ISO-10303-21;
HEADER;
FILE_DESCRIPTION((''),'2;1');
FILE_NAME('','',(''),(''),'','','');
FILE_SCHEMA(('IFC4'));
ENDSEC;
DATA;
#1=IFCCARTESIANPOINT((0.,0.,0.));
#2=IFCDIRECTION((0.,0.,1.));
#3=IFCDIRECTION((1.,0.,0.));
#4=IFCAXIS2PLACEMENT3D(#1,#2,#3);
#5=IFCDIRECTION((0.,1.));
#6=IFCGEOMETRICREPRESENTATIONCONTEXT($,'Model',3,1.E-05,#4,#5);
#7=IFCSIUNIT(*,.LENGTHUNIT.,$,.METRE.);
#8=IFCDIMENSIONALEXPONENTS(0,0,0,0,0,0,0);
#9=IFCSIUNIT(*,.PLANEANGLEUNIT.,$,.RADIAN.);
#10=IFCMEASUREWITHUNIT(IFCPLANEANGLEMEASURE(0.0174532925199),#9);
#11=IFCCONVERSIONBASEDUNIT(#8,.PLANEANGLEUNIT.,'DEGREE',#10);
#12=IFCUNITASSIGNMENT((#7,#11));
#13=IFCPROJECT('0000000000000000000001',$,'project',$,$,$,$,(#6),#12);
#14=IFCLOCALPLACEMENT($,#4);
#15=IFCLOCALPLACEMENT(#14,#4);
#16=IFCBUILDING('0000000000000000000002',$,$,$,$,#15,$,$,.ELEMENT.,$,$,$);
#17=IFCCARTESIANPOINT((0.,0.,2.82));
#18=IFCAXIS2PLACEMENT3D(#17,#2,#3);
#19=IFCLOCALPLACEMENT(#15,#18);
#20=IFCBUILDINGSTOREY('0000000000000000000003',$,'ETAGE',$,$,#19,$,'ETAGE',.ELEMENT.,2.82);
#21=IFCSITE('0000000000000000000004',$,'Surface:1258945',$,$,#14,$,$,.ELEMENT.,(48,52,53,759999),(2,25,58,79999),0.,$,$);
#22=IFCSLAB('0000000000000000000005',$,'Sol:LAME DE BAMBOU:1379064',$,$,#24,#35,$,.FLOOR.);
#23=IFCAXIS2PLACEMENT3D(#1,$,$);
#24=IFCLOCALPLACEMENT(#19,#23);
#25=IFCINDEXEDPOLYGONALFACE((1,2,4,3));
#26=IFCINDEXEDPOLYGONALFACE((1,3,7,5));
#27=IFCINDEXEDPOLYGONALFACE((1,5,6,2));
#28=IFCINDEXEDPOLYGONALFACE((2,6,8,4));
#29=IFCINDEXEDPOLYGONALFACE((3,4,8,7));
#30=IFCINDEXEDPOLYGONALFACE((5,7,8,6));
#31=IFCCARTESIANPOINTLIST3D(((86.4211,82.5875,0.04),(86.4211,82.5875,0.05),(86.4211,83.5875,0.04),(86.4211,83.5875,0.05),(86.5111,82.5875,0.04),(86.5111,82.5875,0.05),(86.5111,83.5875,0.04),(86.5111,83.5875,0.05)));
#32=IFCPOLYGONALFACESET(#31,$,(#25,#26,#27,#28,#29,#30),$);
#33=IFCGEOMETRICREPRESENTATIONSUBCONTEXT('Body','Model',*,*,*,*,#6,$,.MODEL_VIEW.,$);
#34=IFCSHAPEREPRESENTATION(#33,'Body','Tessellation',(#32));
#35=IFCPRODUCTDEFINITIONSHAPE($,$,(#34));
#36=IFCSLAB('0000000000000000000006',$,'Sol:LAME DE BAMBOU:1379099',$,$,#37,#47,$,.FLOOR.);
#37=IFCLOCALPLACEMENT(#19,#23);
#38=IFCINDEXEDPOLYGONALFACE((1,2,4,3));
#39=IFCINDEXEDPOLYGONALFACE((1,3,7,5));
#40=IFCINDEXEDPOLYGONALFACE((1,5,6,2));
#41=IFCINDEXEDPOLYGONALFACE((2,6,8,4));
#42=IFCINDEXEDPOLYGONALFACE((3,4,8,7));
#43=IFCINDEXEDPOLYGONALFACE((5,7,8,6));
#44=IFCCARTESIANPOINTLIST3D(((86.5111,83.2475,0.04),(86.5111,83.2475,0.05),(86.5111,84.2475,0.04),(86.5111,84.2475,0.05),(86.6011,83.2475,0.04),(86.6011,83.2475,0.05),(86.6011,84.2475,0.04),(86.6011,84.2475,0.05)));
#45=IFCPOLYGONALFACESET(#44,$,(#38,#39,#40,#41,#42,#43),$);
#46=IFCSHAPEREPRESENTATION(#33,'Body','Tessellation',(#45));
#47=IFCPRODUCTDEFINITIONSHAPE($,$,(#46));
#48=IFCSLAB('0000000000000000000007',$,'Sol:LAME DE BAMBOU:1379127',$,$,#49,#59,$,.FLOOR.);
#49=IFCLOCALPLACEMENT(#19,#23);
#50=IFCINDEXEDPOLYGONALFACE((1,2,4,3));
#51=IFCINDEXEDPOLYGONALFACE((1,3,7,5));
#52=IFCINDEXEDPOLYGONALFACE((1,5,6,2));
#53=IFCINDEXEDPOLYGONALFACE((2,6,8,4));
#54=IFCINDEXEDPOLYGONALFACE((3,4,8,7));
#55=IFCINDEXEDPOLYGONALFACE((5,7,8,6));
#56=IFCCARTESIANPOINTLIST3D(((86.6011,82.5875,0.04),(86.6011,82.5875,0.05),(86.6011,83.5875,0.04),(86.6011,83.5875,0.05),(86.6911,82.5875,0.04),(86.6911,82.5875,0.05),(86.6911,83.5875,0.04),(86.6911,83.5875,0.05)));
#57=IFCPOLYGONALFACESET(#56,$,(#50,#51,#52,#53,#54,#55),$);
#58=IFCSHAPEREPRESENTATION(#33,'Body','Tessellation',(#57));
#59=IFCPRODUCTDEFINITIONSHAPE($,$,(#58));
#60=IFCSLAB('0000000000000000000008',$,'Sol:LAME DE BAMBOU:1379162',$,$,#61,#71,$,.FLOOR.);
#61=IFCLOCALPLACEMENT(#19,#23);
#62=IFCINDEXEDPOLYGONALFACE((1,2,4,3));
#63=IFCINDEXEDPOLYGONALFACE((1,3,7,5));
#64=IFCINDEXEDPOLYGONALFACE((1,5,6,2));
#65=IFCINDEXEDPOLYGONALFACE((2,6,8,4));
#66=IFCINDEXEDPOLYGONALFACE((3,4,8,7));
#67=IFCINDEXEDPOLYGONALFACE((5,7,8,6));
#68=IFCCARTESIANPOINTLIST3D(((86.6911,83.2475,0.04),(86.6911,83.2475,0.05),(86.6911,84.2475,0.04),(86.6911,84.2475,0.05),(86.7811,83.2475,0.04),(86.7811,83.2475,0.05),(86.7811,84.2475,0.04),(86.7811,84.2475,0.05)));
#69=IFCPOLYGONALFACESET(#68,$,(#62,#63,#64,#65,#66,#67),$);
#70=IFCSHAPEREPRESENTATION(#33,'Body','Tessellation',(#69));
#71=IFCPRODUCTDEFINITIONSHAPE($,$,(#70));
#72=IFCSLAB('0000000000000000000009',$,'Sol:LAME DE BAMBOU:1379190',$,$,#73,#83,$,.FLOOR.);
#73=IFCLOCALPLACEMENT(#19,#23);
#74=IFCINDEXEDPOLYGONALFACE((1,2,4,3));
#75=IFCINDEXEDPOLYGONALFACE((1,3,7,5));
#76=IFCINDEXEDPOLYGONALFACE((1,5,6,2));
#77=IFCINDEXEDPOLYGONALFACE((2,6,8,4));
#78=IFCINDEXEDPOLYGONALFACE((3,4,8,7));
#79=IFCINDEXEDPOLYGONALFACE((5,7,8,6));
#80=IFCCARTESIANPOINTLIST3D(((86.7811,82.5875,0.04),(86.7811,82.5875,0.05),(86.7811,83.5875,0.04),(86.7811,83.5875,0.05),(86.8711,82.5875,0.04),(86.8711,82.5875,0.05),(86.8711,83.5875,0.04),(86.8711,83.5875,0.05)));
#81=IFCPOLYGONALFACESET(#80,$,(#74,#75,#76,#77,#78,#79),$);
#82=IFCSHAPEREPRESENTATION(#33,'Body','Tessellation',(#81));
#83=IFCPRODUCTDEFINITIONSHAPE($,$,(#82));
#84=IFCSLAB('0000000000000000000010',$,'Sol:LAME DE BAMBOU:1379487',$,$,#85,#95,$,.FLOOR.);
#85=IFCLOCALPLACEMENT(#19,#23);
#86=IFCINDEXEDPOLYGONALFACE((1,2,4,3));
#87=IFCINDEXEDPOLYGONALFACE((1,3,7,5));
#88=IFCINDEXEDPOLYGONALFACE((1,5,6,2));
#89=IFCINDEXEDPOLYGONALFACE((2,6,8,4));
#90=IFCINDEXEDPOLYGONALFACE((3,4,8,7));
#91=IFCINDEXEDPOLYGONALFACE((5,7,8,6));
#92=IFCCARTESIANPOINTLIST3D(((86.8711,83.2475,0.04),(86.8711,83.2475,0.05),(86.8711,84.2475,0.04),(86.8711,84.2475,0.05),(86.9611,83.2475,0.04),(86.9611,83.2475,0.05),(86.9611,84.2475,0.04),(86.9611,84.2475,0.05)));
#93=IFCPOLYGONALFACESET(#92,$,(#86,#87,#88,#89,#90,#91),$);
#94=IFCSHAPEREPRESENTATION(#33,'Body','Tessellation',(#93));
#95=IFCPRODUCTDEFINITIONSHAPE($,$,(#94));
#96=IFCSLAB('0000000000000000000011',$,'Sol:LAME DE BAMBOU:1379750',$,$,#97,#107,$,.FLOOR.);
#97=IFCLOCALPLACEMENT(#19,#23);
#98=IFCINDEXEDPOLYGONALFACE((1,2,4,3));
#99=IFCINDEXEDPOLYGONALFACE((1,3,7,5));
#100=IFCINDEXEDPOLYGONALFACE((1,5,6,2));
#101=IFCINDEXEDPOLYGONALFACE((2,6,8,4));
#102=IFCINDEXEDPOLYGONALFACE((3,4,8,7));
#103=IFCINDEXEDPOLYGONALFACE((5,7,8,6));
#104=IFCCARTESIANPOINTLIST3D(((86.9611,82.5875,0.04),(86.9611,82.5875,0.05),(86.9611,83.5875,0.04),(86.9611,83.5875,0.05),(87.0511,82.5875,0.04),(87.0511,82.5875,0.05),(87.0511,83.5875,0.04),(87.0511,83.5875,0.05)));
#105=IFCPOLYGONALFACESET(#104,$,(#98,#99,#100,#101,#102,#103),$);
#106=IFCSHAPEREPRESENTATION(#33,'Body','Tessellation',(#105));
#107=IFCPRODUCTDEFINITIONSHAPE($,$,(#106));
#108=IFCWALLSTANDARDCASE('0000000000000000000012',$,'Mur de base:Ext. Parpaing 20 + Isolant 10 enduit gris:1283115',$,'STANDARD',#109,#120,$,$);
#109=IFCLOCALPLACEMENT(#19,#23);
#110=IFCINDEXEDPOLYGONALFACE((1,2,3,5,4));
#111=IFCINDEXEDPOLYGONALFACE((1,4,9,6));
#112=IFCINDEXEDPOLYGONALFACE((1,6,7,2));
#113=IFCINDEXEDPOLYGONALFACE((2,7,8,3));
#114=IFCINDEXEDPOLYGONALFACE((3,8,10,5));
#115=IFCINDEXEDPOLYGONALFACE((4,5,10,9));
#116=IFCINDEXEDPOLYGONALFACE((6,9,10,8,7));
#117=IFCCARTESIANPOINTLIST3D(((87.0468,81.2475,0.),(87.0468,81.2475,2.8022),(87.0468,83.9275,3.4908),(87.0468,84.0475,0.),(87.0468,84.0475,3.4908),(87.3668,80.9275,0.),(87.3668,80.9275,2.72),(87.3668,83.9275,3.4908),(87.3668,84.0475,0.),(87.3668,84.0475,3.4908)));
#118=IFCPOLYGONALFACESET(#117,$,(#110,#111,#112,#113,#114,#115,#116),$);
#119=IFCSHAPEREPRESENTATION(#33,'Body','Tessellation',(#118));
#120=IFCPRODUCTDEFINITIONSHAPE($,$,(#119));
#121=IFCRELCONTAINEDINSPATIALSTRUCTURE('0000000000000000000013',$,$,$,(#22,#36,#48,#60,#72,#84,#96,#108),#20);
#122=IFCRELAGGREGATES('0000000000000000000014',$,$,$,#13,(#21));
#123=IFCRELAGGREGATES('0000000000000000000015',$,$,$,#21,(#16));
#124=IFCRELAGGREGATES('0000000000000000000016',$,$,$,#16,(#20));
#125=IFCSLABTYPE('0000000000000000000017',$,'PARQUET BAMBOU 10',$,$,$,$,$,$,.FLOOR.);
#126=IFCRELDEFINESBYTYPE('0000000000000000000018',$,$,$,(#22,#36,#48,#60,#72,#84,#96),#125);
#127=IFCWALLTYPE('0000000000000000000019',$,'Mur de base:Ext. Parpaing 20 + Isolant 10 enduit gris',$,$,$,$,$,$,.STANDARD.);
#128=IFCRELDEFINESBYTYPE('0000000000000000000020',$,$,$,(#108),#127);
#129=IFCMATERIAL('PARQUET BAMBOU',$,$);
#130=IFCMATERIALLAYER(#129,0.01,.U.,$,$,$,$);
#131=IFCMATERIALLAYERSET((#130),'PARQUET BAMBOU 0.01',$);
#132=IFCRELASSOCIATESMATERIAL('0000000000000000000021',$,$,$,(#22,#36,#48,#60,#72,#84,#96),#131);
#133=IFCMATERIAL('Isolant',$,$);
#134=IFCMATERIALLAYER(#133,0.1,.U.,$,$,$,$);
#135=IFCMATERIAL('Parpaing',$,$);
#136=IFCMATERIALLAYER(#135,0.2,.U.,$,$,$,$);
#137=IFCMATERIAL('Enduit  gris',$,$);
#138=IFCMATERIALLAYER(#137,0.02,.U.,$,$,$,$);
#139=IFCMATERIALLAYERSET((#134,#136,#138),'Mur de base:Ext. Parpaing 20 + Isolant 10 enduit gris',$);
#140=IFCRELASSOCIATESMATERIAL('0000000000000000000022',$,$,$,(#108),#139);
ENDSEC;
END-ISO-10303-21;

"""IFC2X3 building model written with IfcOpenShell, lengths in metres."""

from ifc_helpers import new_model, entity, si_unit, converted_unit, direction, frame, origin_with_axes, place, context, subcontext, project, spatial, polyline, outline, extrude, clip, halfspace, material, layer, layer_set, layer_usage, type_object, element, save


model = new_model("IFC2X3")

# Units and contexts
model_context = context("Model", 3, precision=1e-05, world=origin_with_axes(), true_north=direction((0.0, 1.0)))
body_context = subcontext(model_context, "Body", "Model", "MODEL_VIEW")
ifc_project = project(units=[si_unit("LENGTHUNIT", "METRE"), converted_unit("PLANEANGLEUNIT", "DEGREE", entity("IfcPlaneAngleMeasure", 0.0174532925199), si_unit("PLANEANGLEUNIT", "RADIAN"), dimensions=[0, 0, 0, 0, 0, 0, 0])], contexts=[model_context])

# Site, building, storey
site_placement = place(None, origin_with_axes())
site = spatial("IfcSite", under=ifc_project, at=site_placement, Name="Surface:1258945", CompositionType="ELEMENT", RefLatitude=(48, 52, 53, 759999), RefLongitude=(2, 25, 58, 79999), RefElevation=0.0)
building_placement = place(site_placement, origin_with_axes())
building = spatial("IfcBuilding", under=site, at=building_placement, CompositionType="ELEMENT")
storey_placement = place(building_placement, frame((0.0, 0.0, 2.82), z_axis=(0.0, 0.0, 1.0), x_axis=(1.0, 0.0, 0.0)))
storey = spatial("IfcBuildingStorey", under=building, at=storey_placement, Name="ETAGE", LongName="ETAGE", CompositionType="ELEMENT", Elevation=2.82)

# Slabs
ifc_material_1 = material(Name="PARQUET BAMBOU")
ifc_layer_1 = layer(ifc_material_1, 0.01, ventilated="UNKNOWN")
ifc_layer_set_1 = layer_set([ifc_layer_1], Name="PARQUET BAMBOU 0.01")
slab_type = type_object("IfcSlabType", Name="PARQUET BAMBOU 10", PredefinedType="FLOOR")
ifc_layer_usage_1 = layer_usage(ifc_layer_set_1, "AXIS3", "NEGATIVE", 0.01)
slab_1_placement = place(storey_placement, frame((86.4211, 83.5875, 0.05), z_axis=(0.0, 0.0, 1.0), x_axis=(1.0, 0.0, 0.0)))
element("IfcSlab", 1, at=slab_1_placement, inside=storey, type_object=slab_type, material=ifc_layer_usage_1, Name="Sol:LAME DE BAMBOU:1379064", PredefinedType="FLOOR", context=body_context, shape_type="SweptSolid", body=[
    extrude(outline(polyline([(0.0, 0.0), (0.0, -1.0), (0.09, -1.0), (0.09, 0.0), (0.0, 0.0)])), frame((0.0, 0.0, -0.01), z_axis=(0.0, 0.0, 1.0), x_axis=(1.0, 0.0, 0.0)), (0.0, 0.0, 1.0), 0.01),
])
ifc_layer_usage_2 = layer_usage(ifc_layer_set_1, "AXIS3", "NEGATIVE", 0.01)
slab_2_placement = place(storey_placement, frame((86.5111, 84.2475, 0.05), z_axis=(0.0, 0.0, 1.0), x_axis=(1.0, 0.0, 0.0)))
element("IfcSlab", 2, at=slab_2_placement, inside=storey, type_object=slab_type, material=ifc_layer_usage_2, Name="Sol:LAME DE BAMBOU:1379099", PredefinedType="FLOOR", context=body_context, shape_type="SweptSolid", body=[
    extrude(outline(polyline([(0.0, 0.0), (0.0, -1.0), (0.09, -1.0), (0.09, 0.0), (0.0, 0.0)])), frame((0.0, 0.0, -0.01), z_axis=(0.0, 0.0, 1.0), x_axis=(1.0, 0.0, 0.0)), (0.0, 0.0, 1.0), 0.01),
])
ifc_layer_usage_3 = layer_usage(ifc_layer_set_1, "AXIS3", "NEGATIVE", 0.01)
slab_3_placement = place(storey_placement, frame((86.6011, 83.5875, 0.05), z_axis=(0.0, 0.0, 1.0), x_axis=(1.0, 0.0, 0.0)))
element("IfcSlab", 3, at=slab_3_placement, inside=storey, type_object=slab_type, material=ifc_layer_usage_3, Name="Sol:LAME DE BAMBOU:1379127", PredefinedType="FLOOR", context=body_context, shape_type="SweptSolid", body=[
    extrude(outline(polyline([(0.0, 0.0), (0.0, -1.0), (0.09, -1.0), (0.09, 0.0), (0.0, 0.0)])), frame((0.0, 0.0, -0.01), z_axis=(0.0, 0.0, 1.0), x_axis=(1.0, 0.0, 0.0)), (0.0, 0.0, 1.0), 0.01),
])
ifc_layer_usage_4 = layer_usage(ifc_layer_set_1, "AXIS3", "NEGATIVE", 0.01)
slab_4_placement = place(storey_placement, frame((86.6911, 84.2475, 0.05), z_axis=(0.0, 0.0, 1.0), x_axis=(1.0, 0.0, 0.0)))
element("IfcSlab", 4, at=slab_4_placement, inside=storey, type_object=slab_type, material=ifc_layer_usage_4, Name="Sol:LAME DE BAMBOU:1379162", PredefinedType="FLOOR", context=body_context, shape_type="SweptSolid", body=[
    extrude(outline(polyline([(0.0, 0.0), (0.0, -1.0), (0.09, -1.0), (0.09, 0.0), (0.0, 0.0)])), frame((0.0, 0.0, -0.01), z_axis=(0.0, 0.0, 1.0), x_axis=(1.0, 0.0, 0.0)), (0.0, 0.0, 1.0), 0.01),
])
ifc_layer_usage_5 = layer_usage(ifc_layer_set_1, "AXIS3", "NEGATIVE", 0.01)
slab_5_placement = place(storey_placement, frame((86.7811, 83.5875, 0.05), z_axis=(0.0, 0.0, 1.0), x_axis=(1.0, 0.0, 0.0)))
element("IfcSlab", 5, at=slab_5_placement, inside=storey, type_object=slab_type, material=ifc_layer_usage_5, Name="Sol:LAME DE BAMBOU:1379190", PredefinedType="FLOOR", context=body_context, shape_type="SweptSolid", body=[
    extrude(outline(polyline([(0.0, 0.0), (0.0, -1.0), (0.09, -1.0), (0.09, 0.0), (0.0, 0.0)])), frame((0.0, 0.0, -0.01), z_axis=(0.0, 0.0, 1.0), x_axis=(1.0, 0.0, 0.0)), (0.0, 0.0, 1.0), 0.01),
])
ifc_layer_usage_6 = layer_usage(ifc_layer_set_1, "AXIS3", "NEGATIVE", 0.01)
slab_6_placement = place(storey_placement, frame((86.8711, 84.2475, 0.05), z_axis=(0.0, 0.0, 1.0), x_axis=(1.0, 0.0, 0.0)))
element("IfcSlab", 6, at=slab_6_placement, inside=storey, type_object=slab_type, material=ifc_layer_usage_6, Name="Sol:LAME DE BAMBOU:1379487", PredefinedType="FLOOR", context=body_context, shape_type="SweptSolid", body=[
    extrude(outline(polyline([(0.0, 0.0), (0.0, -1.0), (0.09, -1.0), (0.09, 0.0), (0.0, 0.0)])), frame((0.0, 0.0, -0.01), z_axis=(0.0, 0.0, 1.0), x_axis=(1.0, 0.0, 0.0)), (0.0, 0.0, 1.0), 0.01),
])
ifc_layer_usage_7 = layer_usage(ifc_layer_set_1, "AXIS3", "NEGATIVE", 0.01)
slab_7_placement = place(storey_placement, frame((86.9611, 83.5875, 0.05), z_axis=(0.0, 0.0, 1.0), x_axis=(1.0, 0.0, 0.0)))
element("IfcSlab", 7, at=slab_7_placement, inside=storey, type_object=slab_type, material=ifc_layer_usage_7, Name="Sol:LAME DE BAMBOU:1379750", PredefinedType="FLOOR", context=body_context, shape_type="SweptSolid", body=[
    extrude(outline(polyline([(0.0, 0.0), (0.0, -1.0), (0.09, -1.0), (0.09, 0.0), (0.0, 0.0)])), frame((0.0, 0.0, -0.01), z_axis=(0.0, 0.0, 1.0), x_axis=(1.0, 0.0, 0.0)), (0.0, 0.0, 1.0), 0.01),
])

# Wall
ifc_material_2 = material(Name="Isolant")
ifc_layer_2 = layer(ifc_material_2, 0.1, ventilated="UNKNOWN")
ifc_material_3 = material(Name="Parpaing")
ifc_layer_3 = layer(ifc_material_3, 0.2, ventilated="UNKNOWN")
ifc_material_4 = material(Name="Enduit  gris")
ifc_layer_4 = layer(ifc_material_4, 0.02, ventilated="UNKNOWN")
ifc_layer_set_2 = layer_set([ifc_layer_2, ifc_layer_3, ifc_layer_4], Name="Mur de base:Ext. Parpaing 20 + Isolant 10 enduit gris")
ifc_layer_usage_8 = layer_usage(ifc_layer_set_2, "AXIS2", "POSITIVE", -0.16)
wall_type_1 = type_object("IfcWallType", Name="Mur de base:Ext. Parpaing 20 + Isolant 10 enduit gris", PredefinedType="STANDARD")
wall_1_placement = place(storey_placement, frame((87.2068, 84.0475, 0.0), z_axis=(0.0, 0.0, 1.0), x_axis=(0.0, -1.0, 0.0)))
element("IfcWallStandardCase", 8, at=wall_1_placement, inside=storey, type_object=wall_type_1, material=ifc_layer_usage_8, Name="Mur de base:Ext. Parpaing 20 + Isolant 10 enduit gris:1283115", ObjectType="STANDARD", context=body_context, shape_type="Clipping", body=[
    clip(extrude(outline(polyline([(0.0, -0.16), (2.8, -0.16), (3.12, 0.16), (0.0, 0.16), (0.0, -0.16)])), origin_with_axes(), (0.0, 0.0, 1.0), 3.4908), halfspace(frame((0.8488, 0.0, 3.3036), z_axis=(-0.248865, 0.0, -0.968538), x_axis=(0.0, 1.0, 0.0)), True)),
])

save(model, "model.ifc")
